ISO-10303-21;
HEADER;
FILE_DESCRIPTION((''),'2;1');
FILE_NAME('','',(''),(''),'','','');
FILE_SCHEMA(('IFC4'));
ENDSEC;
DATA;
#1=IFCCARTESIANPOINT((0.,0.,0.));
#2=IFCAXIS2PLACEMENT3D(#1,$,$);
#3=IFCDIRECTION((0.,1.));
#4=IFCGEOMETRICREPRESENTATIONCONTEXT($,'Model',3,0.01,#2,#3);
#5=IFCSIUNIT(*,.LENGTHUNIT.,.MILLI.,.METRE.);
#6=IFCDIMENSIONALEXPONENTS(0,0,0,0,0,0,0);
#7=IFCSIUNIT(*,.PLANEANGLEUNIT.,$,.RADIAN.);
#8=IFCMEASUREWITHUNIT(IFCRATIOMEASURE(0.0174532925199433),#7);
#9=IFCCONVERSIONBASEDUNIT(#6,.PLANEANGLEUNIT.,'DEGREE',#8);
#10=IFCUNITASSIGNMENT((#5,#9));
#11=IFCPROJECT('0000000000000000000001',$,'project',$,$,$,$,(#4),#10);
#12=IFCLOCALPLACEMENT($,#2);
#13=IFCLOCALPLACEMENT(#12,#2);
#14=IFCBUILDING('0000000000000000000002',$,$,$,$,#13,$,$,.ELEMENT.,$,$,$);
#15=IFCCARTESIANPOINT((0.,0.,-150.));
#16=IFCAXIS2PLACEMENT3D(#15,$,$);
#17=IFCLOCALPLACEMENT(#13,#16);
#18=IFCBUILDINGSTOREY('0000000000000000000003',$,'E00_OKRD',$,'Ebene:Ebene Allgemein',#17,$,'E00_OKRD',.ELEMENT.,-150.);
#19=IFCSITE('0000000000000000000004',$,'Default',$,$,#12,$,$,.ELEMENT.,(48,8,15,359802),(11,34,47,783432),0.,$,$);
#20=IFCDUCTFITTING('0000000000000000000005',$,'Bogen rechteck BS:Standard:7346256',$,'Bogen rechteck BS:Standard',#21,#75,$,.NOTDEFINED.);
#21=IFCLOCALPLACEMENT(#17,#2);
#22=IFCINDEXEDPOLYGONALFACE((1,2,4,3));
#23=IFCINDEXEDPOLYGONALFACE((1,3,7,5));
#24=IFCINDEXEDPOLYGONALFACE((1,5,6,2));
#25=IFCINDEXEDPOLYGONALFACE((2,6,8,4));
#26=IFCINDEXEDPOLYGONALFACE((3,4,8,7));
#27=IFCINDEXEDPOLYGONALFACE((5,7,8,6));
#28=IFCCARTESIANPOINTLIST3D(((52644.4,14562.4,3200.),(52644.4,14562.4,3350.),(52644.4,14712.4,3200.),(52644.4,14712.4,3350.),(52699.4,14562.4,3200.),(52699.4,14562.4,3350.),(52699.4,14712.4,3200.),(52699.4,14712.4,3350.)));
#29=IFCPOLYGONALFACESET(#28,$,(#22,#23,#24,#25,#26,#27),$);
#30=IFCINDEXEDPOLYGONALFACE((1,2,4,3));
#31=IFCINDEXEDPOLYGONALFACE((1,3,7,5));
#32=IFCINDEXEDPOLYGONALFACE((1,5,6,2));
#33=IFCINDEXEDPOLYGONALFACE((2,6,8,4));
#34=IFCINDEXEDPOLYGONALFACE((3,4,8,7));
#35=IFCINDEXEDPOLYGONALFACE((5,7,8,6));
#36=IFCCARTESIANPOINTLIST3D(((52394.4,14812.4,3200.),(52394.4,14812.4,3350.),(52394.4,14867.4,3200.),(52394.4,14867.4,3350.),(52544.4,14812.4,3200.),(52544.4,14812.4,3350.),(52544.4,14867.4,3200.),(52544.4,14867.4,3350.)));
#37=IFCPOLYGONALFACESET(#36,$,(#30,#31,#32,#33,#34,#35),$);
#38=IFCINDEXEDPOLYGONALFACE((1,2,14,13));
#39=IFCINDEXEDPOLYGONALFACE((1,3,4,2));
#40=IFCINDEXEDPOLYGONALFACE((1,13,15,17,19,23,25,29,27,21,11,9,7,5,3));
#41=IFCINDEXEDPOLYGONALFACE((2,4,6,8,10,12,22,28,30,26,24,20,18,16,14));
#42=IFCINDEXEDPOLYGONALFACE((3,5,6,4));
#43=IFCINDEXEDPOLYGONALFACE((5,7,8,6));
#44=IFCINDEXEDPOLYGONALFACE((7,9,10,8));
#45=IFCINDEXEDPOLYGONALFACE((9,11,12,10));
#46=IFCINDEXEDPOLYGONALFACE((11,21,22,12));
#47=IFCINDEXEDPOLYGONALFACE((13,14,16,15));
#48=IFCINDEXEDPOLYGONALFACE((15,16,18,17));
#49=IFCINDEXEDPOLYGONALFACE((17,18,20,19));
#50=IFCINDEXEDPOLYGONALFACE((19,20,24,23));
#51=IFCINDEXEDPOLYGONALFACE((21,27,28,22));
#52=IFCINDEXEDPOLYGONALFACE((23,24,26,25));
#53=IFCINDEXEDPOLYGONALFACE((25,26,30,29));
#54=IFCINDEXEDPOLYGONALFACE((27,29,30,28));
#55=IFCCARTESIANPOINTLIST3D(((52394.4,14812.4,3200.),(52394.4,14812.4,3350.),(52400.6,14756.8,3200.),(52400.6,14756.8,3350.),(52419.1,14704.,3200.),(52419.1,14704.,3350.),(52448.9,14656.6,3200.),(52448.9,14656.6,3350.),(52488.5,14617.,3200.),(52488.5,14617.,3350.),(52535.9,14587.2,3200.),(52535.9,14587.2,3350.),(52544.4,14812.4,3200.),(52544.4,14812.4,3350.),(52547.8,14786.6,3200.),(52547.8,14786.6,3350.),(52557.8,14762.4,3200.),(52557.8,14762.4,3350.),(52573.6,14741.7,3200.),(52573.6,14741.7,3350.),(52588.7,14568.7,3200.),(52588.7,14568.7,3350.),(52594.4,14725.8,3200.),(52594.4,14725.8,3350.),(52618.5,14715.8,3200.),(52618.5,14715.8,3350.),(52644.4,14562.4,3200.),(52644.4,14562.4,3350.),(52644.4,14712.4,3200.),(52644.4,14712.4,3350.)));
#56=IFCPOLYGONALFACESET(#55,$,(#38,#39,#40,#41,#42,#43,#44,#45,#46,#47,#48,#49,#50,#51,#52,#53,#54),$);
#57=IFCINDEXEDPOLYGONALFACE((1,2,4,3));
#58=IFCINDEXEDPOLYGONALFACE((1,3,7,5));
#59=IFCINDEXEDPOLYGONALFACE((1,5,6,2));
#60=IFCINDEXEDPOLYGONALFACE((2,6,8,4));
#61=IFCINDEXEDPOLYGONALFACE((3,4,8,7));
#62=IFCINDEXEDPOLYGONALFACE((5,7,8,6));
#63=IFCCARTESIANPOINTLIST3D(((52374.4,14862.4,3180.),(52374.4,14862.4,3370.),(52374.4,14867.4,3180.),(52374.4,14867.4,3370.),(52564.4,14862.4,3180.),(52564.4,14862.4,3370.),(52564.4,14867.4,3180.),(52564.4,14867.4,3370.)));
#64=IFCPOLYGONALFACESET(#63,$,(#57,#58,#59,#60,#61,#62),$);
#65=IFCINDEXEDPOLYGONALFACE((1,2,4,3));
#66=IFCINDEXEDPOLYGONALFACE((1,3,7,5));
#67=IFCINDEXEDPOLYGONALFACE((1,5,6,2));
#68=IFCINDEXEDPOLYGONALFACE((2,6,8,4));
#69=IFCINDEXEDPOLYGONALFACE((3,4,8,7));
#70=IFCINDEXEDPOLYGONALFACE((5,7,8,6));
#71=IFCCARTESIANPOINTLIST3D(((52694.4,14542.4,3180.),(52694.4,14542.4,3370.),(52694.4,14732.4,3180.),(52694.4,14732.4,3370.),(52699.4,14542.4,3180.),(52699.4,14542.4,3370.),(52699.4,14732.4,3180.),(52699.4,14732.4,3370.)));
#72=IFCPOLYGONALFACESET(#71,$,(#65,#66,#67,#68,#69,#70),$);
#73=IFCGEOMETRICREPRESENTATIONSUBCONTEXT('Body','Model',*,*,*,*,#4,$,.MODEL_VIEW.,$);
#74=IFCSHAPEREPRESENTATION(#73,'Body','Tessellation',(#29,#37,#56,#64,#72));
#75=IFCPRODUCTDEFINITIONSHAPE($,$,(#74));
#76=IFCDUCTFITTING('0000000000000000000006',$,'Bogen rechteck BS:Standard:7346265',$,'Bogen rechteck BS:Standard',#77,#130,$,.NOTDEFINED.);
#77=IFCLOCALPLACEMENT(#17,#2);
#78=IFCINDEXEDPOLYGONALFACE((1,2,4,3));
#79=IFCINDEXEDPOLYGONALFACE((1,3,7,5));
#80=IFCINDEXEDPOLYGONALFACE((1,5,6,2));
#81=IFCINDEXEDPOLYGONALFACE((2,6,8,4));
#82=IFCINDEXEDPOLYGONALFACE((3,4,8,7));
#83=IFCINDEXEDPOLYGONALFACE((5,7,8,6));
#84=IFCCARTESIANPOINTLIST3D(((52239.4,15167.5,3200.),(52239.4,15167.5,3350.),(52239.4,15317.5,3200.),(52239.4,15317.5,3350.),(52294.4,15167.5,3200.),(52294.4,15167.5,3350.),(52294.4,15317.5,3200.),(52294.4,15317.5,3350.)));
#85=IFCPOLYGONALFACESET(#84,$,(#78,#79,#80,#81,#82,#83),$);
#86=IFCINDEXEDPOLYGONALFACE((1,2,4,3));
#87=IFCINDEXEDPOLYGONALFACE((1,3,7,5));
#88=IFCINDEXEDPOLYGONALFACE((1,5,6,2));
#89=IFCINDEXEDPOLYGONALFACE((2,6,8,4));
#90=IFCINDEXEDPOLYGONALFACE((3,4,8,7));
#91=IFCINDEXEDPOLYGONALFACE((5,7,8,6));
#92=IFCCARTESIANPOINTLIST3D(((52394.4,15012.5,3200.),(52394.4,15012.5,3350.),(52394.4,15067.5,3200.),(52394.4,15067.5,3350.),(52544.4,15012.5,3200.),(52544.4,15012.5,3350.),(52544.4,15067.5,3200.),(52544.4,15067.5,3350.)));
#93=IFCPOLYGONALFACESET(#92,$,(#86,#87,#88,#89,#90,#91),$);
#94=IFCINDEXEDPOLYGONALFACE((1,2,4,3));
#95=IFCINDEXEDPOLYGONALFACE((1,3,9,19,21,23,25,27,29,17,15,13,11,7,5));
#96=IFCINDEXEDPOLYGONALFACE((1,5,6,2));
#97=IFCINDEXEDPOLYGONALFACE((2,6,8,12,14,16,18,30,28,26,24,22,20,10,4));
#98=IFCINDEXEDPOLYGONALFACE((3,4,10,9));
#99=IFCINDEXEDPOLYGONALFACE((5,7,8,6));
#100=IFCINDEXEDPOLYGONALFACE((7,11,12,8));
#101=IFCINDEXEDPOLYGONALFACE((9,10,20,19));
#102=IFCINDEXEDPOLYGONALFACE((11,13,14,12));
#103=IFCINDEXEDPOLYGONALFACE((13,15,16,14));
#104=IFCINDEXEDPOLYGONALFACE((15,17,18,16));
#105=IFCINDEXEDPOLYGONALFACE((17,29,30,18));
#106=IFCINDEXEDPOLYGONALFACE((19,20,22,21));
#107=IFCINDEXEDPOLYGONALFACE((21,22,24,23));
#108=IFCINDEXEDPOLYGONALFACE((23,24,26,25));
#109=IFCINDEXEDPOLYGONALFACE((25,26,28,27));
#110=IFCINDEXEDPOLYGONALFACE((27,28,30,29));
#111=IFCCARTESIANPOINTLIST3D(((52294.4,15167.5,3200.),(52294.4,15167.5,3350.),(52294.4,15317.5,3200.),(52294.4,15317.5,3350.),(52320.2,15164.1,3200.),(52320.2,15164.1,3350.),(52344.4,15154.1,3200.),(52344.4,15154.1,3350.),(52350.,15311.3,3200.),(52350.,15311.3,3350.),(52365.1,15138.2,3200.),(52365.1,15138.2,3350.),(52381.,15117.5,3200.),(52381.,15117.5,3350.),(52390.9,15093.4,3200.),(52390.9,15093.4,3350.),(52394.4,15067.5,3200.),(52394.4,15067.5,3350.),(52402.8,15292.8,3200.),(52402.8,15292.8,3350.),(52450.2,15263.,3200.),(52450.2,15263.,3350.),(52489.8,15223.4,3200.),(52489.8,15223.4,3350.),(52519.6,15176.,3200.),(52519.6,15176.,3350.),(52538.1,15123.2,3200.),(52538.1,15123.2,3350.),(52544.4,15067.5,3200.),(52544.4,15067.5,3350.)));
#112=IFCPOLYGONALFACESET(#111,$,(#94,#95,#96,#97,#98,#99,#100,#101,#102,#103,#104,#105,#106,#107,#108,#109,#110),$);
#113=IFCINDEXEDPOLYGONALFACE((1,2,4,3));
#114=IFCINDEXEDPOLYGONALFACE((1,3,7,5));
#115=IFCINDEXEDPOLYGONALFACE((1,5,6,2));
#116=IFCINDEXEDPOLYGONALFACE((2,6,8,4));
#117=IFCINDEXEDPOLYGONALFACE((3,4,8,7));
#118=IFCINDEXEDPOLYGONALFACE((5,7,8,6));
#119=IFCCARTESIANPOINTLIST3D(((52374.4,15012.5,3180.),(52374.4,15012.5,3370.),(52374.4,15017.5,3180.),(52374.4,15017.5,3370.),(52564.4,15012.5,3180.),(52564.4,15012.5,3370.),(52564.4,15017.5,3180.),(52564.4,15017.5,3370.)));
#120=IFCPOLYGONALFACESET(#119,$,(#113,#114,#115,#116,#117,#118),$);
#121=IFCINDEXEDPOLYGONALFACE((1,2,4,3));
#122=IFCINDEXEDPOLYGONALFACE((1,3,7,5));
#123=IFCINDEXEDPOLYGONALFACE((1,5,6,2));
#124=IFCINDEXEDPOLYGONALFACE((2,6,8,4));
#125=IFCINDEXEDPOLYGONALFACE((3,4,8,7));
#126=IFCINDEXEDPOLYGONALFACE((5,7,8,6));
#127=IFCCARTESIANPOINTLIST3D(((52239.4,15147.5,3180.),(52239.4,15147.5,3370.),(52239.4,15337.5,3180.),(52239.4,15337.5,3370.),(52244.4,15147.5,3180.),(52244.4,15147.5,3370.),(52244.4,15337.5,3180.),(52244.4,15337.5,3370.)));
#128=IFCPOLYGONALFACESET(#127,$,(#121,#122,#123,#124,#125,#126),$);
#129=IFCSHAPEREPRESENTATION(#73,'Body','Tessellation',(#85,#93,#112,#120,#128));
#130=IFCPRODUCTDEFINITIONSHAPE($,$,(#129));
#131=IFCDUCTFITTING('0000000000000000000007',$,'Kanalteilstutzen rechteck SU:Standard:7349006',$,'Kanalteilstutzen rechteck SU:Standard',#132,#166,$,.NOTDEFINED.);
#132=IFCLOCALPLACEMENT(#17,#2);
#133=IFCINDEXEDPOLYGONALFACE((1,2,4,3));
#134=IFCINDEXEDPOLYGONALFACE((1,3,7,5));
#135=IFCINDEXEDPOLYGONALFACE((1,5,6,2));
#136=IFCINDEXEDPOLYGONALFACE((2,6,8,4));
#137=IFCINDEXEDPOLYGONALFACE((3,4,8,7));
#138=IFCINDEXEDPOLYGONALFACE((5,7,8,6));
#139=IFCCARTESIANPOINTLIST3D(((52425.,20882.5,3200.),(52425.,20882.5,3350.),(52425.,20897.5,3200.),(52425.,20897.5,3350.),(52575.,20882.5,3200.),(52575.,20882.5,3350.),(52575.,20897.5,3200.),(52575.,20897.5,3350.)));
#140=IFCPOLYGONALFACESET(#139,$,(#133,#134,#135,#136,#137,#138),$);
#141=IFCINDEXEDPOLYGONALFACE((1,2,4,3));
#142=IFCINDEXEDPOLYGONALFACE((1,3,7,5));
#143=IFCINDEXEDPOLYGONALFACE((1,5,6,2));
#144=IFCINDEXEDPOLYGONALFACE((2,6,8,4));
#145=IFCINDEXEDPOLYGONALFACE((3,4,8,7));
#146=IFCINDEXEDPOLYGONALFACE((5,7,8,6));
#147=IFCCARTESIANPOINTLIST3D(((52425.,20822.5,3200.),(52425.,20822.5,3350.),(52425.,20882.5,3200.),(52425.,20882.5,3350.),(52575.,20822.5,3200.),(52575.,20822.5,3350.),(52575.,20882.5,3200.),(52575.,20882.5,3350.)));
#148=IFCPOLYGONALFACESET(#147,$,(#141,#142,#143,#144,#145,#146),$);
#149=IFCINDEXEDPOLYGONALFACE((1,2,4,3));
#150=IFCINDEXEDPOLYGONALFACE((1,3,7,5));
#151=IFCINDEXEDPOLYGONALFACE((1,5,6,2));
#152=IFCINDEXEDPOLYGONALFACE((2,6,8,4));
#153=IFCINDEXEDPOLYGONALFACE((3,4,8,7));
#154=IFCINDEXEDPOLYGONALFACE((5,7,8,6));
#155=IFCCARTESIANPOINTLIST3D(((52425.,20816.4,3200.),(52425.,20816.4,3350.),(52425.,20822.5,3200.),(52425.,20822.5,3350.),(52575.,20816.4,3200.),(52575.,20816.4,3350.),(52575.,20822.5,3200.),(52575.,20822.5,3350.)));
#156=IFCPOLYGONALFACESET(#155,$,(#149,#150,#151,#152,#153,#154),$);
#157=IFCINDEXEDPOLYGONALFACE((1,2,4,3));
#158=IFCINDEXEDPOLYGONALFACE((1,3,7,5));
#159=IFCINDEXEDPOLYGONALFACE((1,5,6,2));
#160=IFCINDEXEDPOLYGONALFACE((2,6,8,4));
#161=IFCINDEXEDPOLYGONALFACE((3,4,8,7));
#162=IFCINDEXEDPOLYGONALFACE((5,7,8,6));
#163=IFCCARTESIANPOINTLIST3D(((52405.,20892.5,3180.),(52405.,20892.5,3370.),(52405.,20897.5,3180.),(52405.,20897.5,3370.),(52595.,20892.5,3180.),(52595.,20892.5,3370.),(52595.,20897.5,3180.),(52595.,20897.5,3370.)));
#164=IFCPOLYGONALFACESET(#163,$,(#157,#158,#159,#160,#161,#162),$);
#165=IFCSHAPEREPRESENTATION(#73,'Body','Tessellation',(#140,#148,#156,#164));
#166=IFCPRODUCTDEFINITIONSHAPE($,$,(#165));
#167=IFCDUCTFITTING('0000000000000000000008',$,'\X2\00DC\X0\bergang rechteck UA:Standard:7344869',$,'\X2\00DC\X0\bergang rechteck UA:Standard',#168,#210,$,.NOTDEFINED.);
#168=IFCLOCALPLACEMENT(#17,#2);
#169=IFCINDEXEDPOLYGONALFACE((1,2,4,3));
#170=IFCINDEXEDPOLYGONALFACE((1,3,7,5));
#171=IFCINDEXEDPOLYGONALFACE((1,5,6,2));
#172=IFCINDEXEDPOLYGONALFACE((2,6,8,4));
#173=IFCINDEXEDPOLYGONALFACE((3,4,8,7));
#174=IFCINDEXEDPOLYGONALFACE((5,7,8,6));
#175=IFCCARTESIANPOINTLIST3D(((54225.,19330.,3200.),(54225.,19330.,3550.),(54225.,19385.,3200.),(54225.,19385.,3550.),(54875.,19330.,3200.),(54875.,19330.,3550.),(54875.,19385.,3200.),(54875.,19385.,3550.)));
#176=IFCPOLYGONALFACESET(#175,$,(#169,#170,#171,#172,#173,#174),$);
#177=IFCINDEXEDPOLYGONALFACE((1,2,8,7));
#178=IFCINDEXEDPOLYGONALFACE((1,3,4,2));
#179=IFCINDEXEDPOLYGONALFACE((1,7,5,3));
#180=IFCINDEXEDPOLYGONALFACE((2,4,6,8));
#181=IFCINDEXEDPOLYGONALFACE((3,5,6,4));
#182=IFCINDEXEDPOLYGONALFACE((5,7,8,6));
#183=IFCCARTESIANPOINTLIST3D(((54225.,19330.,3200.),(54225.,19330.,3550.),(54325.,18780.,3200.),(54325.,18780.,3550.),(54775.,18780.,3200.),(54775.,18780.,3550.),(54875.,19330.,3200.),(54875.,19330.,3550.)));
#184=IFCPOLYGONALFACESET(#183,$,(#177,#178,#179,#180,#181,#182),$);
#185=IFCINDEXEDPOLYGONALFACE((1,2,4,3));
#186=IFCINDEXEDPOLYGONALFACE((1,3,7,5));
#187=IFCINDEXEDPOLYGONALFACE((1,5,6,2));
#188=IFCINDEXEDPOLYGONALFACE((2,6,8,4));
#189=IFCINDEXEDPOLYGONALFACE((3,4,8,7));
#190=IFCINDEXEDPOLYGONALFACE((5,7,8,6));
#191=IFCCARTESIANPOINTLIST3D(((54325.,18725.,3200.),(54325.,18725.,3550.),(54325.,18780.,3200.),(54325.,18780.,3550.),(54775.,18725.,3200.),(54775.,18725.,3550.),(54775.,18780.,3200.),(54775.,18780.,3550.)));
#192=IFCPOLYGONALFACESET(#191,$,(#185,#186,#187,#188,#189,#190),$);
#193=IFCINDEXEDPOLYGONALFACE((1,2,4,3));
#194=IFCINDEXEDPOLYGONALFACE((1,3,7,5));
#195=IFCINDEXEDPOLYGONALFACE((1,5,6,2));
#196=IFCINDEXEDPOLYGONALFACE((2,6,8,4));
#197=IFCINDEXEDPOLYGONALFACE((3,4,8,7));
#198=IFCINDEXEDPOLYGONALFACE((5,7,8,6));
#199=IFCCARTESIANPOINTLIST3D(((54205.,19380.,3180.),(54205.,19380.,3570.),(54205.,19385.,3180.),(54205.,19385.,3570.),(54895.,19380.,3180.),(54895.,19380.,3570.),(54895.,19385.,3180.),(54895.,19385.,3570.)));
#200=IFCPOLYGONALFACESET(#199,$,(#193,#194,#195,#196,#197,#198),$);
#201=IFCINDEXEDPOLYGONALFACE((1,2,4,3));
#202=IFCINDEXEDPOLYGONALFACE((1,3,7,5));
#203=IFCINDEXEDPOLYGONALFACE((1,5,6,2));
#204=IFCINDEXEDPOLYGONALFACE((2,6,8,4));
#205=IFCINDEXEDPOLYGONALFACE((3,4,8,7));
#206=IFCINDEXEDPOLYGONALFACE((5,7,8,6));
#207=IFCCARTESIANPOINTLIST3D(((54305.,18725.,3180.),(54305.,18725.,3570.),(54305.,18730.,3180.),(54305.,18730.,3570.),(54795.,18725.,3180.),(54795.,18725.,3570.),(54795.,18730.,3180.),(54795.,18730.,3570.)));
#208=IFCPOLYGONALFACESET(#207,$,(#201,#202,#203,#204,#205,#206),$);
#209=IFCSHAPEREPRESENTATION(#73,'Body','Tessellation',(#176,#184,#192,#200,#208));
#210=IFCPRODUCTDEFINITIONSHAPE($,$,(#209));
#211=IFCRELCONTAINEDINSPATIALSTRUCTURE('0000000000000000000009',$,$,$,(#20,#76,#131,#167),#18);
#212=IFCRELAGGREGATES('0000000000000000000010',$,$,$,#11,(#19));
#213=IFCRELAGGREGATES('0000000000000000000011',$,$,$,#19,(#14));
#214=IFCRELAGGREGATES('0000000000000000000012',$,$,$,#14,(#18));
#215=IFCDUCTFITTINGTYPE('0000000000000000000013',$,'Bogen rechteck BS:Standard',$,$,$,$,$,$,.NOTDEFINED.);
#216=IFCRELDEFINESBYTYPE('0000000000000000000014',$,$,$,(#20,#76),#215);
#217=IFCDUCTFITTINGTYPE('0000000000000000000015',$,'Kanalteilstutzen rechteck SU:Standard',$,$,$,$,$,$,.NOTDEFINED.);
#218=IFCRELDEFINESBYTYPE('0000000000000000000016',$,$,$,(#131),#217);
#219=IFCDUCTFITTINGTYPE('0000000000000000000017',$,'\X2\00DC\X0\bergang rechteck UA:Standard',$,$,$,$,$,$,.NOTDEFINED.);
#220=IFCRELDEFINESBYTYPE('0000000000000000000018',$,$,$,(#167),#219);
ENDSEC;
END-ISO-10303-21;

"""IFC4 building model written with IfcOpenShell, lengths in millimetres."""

from ifc_helpers import new_model, entity, si_unit, converted_unit, direction, frame, frame_2d, origin, origin_2d_with_axis, place, context, subcontext, project, spatial, polyline, circle_curve, parameter, trimmed, segment, composite_curve, rectangle, outline, extrude, source, transform, mapped, type_object, type_shapes, element, save


model = new_model("IFC4")

# Units and contexts
model_context = context("Model", 3, precision=0.01, world=origin(), true_north=direction((0.0, 1.0)))
body_context = subcontext(model_context, "Body", "Model", "MODEL_VIEW")
ifc_project = project(units=[si_unit("LENGTHUNIT", "METRE", prefix="MILLI"), converted_unit("PLANEANGLEUNIT", "DEGREE", entity("IfcRatioMeasure", 0.0174532925199433), si_unit("PLANEANGLEUNIT", "RADIAN"), dimensions=[0, 0, 0, 0, 0, 0, 0])], contexts=[model_context])

# Site, building, storey
site_placement = place(None, origin())
site = spatial("IfcSite", under=ifc_project, at=site_placement, Name="Default", CompositionType="ELEMENT", RefLatitude=(48, 8, 15, 359802), RefLongitude=(11, 34, 47, 783432), RefElevation=0.0)
building_placement = place(site_placement, origin())
building = spatial("IfcBuilding", under=site, at=building_placement, CompositionType="ELEMENT")
storey_placement = place(building_placement, frame((0.0, 0.0, -150.0)))
storey = spatial("IfcBuildingStorey", under=building, at=storey_placement, Name="E00_OKRD", ObjectType="Ebene:Ebene Allgemein", LongName="E00_OKRD", CompositionType="ELEMENT", Elevation=-150.0)

# Duct fittings
duct_fitting_type_1 = type_object("IfcDuctFittingType", Name="Bogen rechteck BS:Standard", PredefinedType="NOTDEFINED")
shared_shape_1 = source(origin(), body_context, "Body", "SweptSolid", [
    extrude(rectangle(XDim=55.0, YDim=150.0, at=origin_2d_with_axis()), frame((0.0, 202.5, -75.0), z_axis=(0.0, 0.0, 1.0), x_axis=(0.0, 1.0, 0.0)), (0.0, 0.0, 1.0), 150.0),
    extrude(rectangle(XDim=150.0, YDim=55.0, at=frame_2d((0.0, 0.0), x_axis=(1.0, 0.0))), frame((-202.5, 0.0, -75.0), z_axis=(0.0, 0.0, 1.0), x_axis=(0.0, -1.0, 0.0)), (0.0, 0.0, 1.0), 150.0),
    extrude(outline(composite_curve([segment(polyline([(-162.5, -87.5), (-12.5, -87.5)]), True, "CONTINUOUS"), segment(trimmed(circle_curve(frame_2d((87.5, -87.5), x_axis=(0.0, 1.0)), 100.0), [parameter(0.0)], [parameter(90.0)], True, "PARAMETER"), False, "CONTINUOUS"), segment(polyline([(87.5, 12.5), (87.5, 162.5)]), True, "CONTINUOUS"), segment(trimmed(circle_curve(frame_2d((87.5, -87.5), x_axis=(0.0, 1.0)), 250.0), [parameter(0.0)], [parameter(90.0)], True, "PARAMETER"), True, "CONTINUOUS")], self_intersect=False)), frame((-87.5, 87.5, -75.0), z_axis=(0.0, 0.0, 1.0), x_axis=(-1.0, 0.0, 0.0)), (0.0, 0.0, 1.0), 150.0),
    extrude(rectangle(XDim=5.0, YDim=190.0, at=frame_2d((0.0, 0.0), x_axis=(1.0, 0.0))), frame((-227.5, 0.0, -95.0)), (0.0, 0.0, 1.0), 190.0),
    extrude(rectangle(XDim=5.0, YDim=190.0, at=frame_2d((0.0, 0.0), x_axis=(1.0, 0.0))), frame((0.0, 227.5, -95.0), z_axis=(0.0, 0.0, 1.0), x_axis=(0.0, 1.0, 0.0)), (0.0, 0.0, 1.0), 190.0),
])
type_shapes(duct_fitting_type_1, [shared_shape_1])
for number, where, z_axis, x_axis, name in (
    (1, (52469.4, 14637.4, 3275.0), (0.0, 0.0, 1.0), (0.0, -1.0, 0.0), "Bogen rechteck BS:Standard:7346256"),
    (2, (52469.4, 15242.5, 3275.0), (0.0, 0.0, 1.0), (0.0, 1.0, 0.0), "Bogen rechteck BS:Standard:7346265"),
):
    element("IfcDuctFitting", number, at=place(storey_placement, frame(where, z_axis=z_axis, x_axis=x_axis)), inside=storey, type_object=duct_fitting_type_1, Name=name, ObjectType="Bogen rechteck BS:Standard", PredefinedType="NOTDEFINED", context=body_context, shape_type="MappedRepresentation", body=[
        mapped(shared_shape_1, transform((0.0, 0.0, 0.0), scale=1.0)),
    ])
duct_fitting_type_2 = type_object("IfcDuctFittingType", Name="Kanalteilstutzen rechteck SU:Standard", PredefinedType="NOTDEFINED")
shared_shape_2 = source(origin(), body_context, "Body", "SweptSolid", [
    extrude(rectangle(XDim=15.0, YDim=150.0, at=frame_2d((0.0, 0.0), x_axis=(1.0, 0.0))), frame((67.5, 0.0, -75.0)), (0.0, 0.0, 1.0), 150.0),
    extrude(rectangle(XDim=60.0, YDim=150.0, at=frame_2d((0.0, 0.0), x_axis=(1.0, 0.0))), frame((30.0, 0.0, -75.0)), (0.0, 0.0, 1.0), 150.0),
    extrude(rectangle(XDim=6.1, YDim=150.0, at=frame_2d((0.0, 0.0), x_axis=(1.0, 0.0))), frame((-3.0, 0.0, -75.0)), (0.0, 0.0, 1.0), 150.0),
    extrude(rectangle(XDim=5.0, YDim=190.0, at=origin_2d_with_axis()), frame((72.5, 0.0, -95.0)), (0.0, 0.0, 1.0), 190.0),
])
type_shapes(duct_fitting_type_2, [shared_shape_2])
duct_fitting_1_placement = place(storey_placement, frame((52500.0, 20822.5, 3275.0), z_axis=(0.0, 0.0, -1.0), x_axis=(0.0, 1.0, 0.0)))
element("IfcDuctFitting", 3, at=duct_fitting_1_placement, inside=storey, type_object=duct_fitting_type_2, Name="Kanalteilstutzen rechteck SU:Standard:7349006", ObjectType="Kanalteilstutzen rechteck SU:Standard", PredefinedType="NOTDEFINED", context=body_context, shape_type="MappedRepresentation", body=[
    mapped(shared_shape_2, transform((0.0, 0.0, 0.0), scale=1.0)),
])
duct_fitting_type_3 = type_object("IfcDuctFittingType", Name="Übergang rechteck UA:Standard", PredefinedType="NOTDEFINED")
shared_shape_3 = source(origin(), body_context, "Body", "SweptSolid", [
    extrude(rectangle(XDim=55.0, YDim=650.0, at=frame_2d((0.0, 0.0), x_axis=(1.0, 0.0))), frame((632.5, 0.0, -175.0)), (0.0, 0.0, 1.0), 350.0),
    extrude(outline(polyline([(-230.3, -270.6), (328.7, -270.6), (212.4, 369.0), (-310.8, 172.2), (-230.3, -270.6)])), frame((330.0, 0.0, -175.0), z_axis=(0.0, 0.0, 1.0), x_axis=(0.98387, -0.178885, 0.0)), (0.0, 0.0, 1.0), 350.0),
    extrude(rectangle(XDim=55.0, YDim=450.0, at=frame_2d((0.0, 0.0), x_axis=(1.0, 0.0))), frame((27.5, 0.0, -175.0)), (0.0, 0.0, 1.0), 350.0),
    extrude(rectangle(XDim=5.0, YDim=690.0, at=frame_2d((0.0, 0.0), x_axis=(1.0, 0.0))), frame((657.5, 0.0, -195.0)), (0.0, 0.0, 1.0), 390.0),
    extrude(rectangle(XDim=5.0, YDim=490.0, at=frame_2d((0.0, 0.0), x_axis=(1.0, 0.0))), frame((2.5, 0.0, -195.0)), (0.0, 0.0, 1.0), 390.0),
])
type_shapes(duct_fitting_type_3, [shared_shape_3])
duct_fitting_2_placement = place(storey_placement, frame((54550.0, 18725.0, 3375.0), z_axis=(0.0, 0.0, 1.0), x_axis=(0.0, 1.0, 0.0)))
element("IfcDuctFitting", 4, at=duct_fitting_2_placement, inside=storey, type_object=duct_fitting_type_3, Name="Übergang rechteck UA:Standard:7344869", ObjectType="Übergang rechteck UA:Standard", PredefinedType="NOTDEFINED", context=body_context, shape_type="MappedRepresentation", body=[
    mapped(shared_shape_3, transform((0.0, 0.0, 0.0), scale=1.0)),
])

save(model, "model.ifc")
